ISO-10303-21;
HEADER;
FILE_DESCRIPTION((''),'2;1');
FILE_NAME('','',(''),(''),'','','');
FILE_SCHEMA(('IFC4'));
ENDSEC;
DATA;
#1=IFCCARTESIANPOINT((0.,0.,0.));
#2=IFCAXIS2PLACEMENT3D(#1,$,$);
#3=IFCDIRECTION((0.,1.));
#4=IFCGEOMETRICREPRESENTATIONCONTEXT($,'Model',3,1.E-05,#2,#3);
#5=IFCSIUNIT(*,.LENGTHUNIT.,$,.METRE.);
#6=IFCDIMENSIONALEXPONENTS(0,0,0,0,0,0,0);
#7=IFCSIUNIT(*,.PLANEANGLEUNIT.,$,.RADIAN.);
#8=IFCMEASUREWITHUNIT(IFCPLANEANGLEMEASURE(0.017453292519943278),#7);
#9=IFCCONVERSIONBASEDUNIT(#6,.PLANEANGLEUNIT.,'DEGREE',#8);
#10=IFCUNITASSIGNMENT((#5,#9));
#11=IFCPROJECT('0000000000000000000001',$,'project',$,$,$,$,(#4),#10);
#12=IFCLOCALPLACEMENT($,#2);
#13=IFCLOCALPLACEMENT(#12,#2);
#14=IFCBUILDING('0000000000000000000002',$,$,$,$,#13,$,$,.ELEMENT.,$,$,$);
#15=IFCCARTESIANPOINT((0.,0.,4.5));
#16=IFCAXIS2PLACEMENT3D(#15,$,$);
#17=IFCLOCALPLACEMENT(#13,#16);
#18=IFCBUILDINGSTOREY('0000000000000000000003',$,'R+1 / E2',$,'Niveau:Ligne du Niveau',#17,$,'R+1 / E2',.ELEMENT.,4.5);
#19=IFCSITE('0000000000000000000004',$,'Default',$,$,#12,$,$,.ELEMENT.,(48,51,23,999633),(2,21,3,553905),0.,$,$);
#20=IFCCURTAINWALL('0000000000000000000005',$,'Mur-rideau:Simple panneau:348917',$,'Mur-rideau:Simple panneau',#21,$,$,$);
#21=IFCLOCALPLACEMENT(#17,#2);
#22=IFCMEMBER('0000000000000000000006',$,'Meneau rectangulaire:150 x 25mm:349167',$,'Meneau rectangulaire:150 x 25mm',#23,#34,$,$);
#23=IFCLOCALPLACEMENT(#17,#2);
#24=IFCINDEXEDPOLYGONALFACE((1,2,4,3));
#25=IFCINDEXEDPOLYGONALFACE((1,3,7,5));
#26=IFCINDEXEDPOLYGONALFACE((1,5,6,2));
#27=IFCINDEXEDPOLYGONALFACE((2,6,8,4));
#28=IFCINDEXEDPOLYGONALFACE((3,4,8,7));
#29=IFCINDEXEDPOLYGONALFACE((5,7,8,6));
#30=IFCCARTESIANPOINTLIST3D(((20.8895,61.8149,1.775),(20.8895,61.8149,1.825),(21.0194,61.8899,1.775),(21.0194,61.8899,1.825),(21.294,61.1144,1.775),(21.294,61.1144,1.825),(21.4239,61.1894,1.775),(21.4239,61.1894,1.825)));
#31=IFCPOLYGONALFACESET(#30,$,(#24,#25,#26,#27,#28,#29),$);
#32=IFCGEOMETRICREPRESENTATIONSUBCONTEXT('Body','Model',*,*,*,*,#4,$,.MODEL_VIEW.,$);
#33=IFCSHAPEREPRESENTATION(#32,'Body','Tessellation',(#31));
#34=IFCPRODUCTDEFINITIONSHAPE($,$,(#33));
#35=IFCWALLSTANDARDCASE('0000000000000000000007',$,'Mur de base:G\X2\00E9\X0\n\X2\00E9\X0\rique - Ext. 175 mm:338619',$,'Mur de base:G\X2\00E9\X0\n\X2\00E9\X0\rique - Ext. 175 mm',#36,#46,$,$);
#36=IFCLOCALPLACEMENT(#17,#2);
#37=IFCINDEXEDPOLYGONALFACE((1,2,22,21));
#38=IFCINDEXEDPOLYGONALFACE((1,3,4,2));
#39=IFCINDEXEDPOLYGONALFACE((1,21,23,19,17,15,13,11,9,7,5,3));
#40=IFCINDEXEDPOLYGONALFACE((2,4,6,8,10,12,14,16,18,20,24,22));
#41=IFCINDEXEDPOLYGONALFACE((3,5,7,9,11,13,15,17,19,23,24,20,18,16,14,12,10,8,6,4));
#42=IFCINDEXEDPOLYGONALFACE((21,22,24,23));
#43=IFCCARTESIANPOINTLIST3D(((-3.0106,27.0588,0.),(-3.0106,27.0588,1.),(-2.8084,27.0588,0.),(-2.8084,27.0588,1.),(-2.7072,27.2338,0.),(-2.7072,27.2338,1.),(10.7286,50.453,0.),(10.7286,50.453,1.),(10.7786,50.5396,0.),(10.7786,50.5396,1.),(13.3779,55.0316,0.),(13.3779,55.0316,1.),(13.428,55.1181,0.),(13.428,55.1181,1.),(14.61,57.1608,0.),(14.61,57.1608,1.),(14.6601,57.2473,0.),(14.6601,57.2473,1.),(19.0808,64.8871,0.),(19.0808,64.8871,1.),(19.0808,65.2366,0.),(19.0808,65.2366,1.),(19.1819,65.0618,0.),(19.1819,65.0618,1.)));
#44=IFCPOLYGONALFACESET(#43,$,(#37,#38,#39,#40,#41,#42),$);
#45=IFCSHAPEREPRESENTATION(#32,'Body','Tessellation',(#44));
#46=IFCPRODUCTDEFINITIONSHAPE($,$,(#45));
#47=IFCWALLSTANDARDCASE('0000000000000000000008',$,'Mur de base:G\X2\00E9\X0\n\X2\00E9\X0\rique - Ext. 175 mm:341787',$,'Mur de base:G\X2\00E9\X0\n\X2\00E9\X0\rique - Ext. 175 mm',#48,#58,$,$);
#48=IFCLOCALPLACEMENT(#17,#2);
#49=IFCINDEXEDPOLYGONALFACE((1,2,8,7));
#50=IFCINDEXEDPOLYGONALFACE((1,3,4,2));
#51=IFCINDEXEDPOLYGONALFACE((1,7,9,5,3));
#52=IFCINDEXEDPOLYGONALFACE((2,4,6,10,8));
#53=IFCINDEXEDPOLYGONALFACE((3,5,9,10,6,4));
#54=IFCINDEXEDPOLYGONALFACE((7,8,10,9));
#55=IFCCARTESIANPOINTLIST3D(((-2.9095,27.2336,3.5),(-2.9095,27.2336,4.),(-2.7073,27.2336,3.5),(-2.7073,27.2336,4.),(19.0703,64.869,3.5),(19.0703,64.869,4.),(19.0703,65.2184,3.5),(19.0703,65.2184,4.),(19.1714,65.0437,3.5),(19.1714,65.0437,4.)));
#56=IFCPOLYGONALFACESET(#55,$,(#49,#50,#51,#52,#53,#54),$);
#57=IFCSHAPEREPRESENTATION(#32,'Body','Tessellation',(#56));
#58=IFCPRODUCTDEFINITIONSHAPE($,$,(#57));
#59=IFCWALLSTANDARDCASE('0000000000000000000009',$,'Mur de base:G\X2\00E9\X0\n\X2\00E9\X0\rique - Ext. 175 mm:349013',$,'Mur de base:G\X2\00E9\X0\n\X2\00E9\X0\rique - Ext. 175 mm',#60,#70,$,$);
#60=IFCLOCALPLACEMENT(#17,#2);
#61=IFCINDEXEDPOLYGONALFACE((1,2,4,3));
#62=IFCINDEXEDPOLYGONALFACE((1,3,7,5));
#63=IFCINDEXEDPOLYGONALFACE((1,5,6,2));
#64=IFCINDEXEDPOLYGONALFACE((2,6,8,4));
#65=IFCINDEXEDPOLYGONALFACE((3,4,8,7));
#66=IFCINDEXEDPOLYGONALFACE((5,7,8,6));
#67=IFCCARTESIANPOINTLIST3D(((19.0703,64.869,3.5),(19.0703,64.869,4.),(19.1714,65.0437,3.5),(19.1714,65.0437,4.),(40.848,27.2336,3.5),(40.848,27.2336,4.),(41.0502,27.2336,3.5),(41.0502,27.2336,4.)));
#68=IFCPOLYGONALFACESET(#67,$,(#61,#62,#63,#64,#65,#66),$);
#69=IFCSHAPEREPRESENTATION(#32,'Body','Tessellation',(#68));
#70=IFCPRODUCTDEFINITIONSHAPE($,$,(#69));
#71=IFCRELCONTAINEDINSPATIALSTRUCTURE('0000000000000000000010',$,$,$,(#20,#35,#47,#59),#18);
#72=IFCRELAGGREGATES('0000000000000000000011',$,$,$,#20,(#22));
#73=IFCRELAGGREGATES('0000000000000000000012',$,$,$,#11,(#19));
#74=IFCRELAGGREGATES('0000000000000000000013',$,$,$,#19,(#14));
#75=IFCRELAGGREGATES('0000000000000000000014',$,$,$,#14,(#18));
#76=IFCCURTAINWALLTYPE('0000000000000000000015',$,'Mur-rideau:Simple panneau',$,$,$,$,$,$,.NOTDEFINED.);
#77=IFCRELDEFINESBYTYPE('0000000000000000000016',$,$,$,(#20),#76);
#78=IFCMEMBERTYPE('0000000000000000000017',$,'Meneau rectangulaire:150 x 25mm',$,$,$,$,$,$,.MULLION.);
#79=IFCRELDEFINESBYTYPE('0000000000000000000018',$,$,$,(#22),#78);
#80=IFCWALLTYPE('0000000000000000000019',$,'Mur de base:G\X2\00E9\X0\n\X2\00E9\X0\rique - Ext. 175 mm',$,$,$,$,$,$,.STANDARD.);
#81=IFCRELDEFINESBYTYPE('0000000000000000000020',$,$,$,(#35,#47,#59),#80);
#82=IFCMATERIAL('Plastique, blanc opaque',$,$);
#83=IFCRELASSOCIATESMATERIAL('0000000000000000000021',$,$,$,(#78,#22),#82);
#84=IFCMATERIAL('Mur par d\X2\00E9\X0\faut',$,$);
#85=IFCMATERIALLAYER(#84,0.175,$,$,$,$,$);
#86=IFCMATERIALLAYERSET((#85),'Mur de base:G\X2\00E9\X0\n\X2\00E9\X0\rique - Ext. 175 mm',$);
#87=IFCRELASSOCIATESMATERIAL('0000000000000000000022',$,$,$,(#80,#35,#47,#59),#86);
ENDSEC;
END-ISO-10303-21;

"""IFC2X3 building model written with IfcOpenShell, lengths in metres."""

from ifc_helpers import new_model, entity, si_unit, converted_unit, direction, frame, origin, origin_2d_with_axis, place, context, subcontext, project, spatial, polyline, rectangle, outline, extrude, source, transform, mapped, material, layer, layer_set, layer_usage, type_object, type_shapes, element, aggregate, save


model = new_model("IFC2X3")

# Units and contexts
model_context = context("Model", 3, precision=1e-05, world=origin(), true_north=direction((0.0, 1.0)))
body_context = subcontext(model_context, "Body", "Model", "MODEL_VIEW")
ifc_project = project(units=[si_unit("LENGTHUNIT", "METRE"), converted_unit("PLANEANGLEUNIT", "DEGREE", entity("IfcPlaneAngleMeasure", 0.017453292519943278), si_unit("PLANEANGLEUNIT", "RADIAN"), dimensions=[0, 0, 0, 0, 0, 0, 0])], contexts=[model_context])

# Site, building, storey
site_placement = place(None, origin())
site = spatial("IfcSite", under=ifc_project, at=site_placement, Name="Default", CompositionType="ELEMENT", RefLatitude=(48, 51, 23, 999633), RefLongitude=(2, 21, 3, 553905), RefElevation=0.0)
building_placement = place(site_placement, origin())
building = spatial("IfcBuilding", under=site, at=building_placement, CompositionType="ELEMENT")
storey_placement = place(building_placement, frame((0.0, 0.0, 4.5)))
storey = spatial("IfcBuildingStorey", under=building, at=storey_placement, Name="R+1 / E2", ObjectType="Niveau:Ligne du Niveau", LongName="R+1 / E2", CompositionType="ELEMENT", Elevation=4.5)

# Curtain wall, member
curtain_wall_type = type_object("IfcCurtainWallType", Name="Mur-rideau:Simple panneau", PredefinedType="NOTDEFINED")
ifc_material_1 = material(Name="Plastique, blanc opaque")
curtain_wall_1_placement = place(storey_placement, frame((0.0, 0.0, -4.5)))
curtain_wall_1 = element("IfcCurtainWall", 1, at=curtain_wall_1_placement, inside=storey, type_object=curtain_wall_type, Name="Mur-rideau:Simple panneau:348917", ObjectType="Mur-rideau:Simple panneau")
member_type_1 = type_object("IfcMemberType", Name="Meneau rectangulaire:150 x 25mm", PredefinedType="MULLION", material=ifc_material_1)
shared_shape_1 = source(origin(), body_context, "Body", "SweptSolid", [
    extrude(rectangle(XDim=0.05, YDim=0.15, at=origin_2d_with_axis()), frame((0.0, 0.0, -0.8089), z_axis=(0.0, 0.0, 1.0), x_axis=(-1.0, 0.0, 0.0)), (0.0, 0.0, 1.0), 0.8089),
])
type_shapes(member_type_1, [shared_shape_1])
member_1_placement = place(curtain_wall_1_placement, frame((21.3589, 61.1519, 6.3), z_axis=(0.5, -0.866025, 0.0), x_axis=(0.0, 0.0, 1.0)))
member_1 = element("IfcMember", 2, at=member_1_placement, type_object=member_type_1, material=ifc_material_1, Name="Meneau rectangulaire:150 x 25mm:349167", ObjectType="Meneau rectangulaire:150 x 25mm", context=body_context, shape_type="MappedRepresentation", body=[
    mapped(shared_shape_1, transform((0.0, 0.0, 0.0), scale=1.0)),
])

aggregate(curtain_wall_1, [member_1])

# Walls
ifc_material_2 = material(Name="Mur par défaut")
ifc_layer_1 = layer(ifc_material_2, 0.175)
ifc_layer_set_1 = layer_set([ifc_layer_1], Name="Mur de base:Générique - Ext. 175 mm")
ifc_layer_usage_1 = layer_usage(ifc_layer_set_1, "AXIS2", "NEGATIVE", 0.0875)
wall_type = type_object("IfcWallType", Name="Mur de base:Générique - Ext. 175 mm", PredefinedType="STANDARD", material=ifc_layer_set_1)
wall_1_placement = place(storey_placement, frame((19.1566, 65.1927, 0.0), z_axis=(0.0, 0.0, 1.0), x_axis=(-0.500842, -0.865539, 0.0)))
element("IfcWallStandardCase", 3, at=wall_1_placement, inside=storey, type_object=wall_type, material=ifc_layer_usage_1, Name="Mur de base:Générique - Ext. 175 mm:338619", ObjectType="Mur de base:Générique - Ext. 175 mm", context=body_context, shape_type="SweptSolid", body=[
    extrude(outline(polyline([(44.1086, -0.0875), (44.0074, 0.0875), (43.8052, 0.0875), (16.9789, 0.0875), (16.8789, 0.0875), (11.6891, 0.0875), (11.5891, 0.0875), (9.2291, 0.0875), (9.1291, 0.0875), (0.3024, 0.0875), (0.1006, 0.0875), (0.0, -0.0875), (44.1086, -0.0875)])), origin(), (0.0, 0.0, 1.0), 1.0),
])
ifc_layer_usage_2 = layer_usage(ifc_layer_set_1, "AXIS2", "NEGATIVE", 0.0875)
wall_2_placement = place(storey_placement, frame((19.1461, 65.1745, 3.5), z_axis=(0.0, 0.0, 1.0), x_axis=(-0.500842, -0.865539, 0.0)))
element("IfcWallStandardCase", 4, at=wall_2_placement, inside=storey, type_object=wall_type, material=ifc_layer_usage_2, Name="Mur de base:Générique - Ext. 175 mm:341787", ObjectType="Mur de base:Générique - Ext. 175 mm", context=body_context, shape_type="SweptSolid", body=[
    extrude(outline(polyline([(43.8857, -0.0875), (43.7845, 0.0875), (0.3024, 0.0875), (0.1006, 0.0875), (0.0, -0.0875), (43.8857, -0.0875)])), origin(), (0.0, 0.0, 1.0), 0.5),
])
ifc_layer_usage_3 = layer_usage(ifc_layer_set_1, "AXIS2", "POSITIVE", -0.0875)
wall_3_placement = place(storey_placement, frame((19.0957, 64.9998, 3.5), z_axis=(0.0, 0.0, 1.0), x_axis=(0.500842, -0.865539, 0.0)))
element("IfcWallStandardCase", 5, at=wall_3_placement, inside=storey, type_object=wall_type, material=ifc_layer_usage_3, Name="Mur de base:Générique - Ext. 175 mm:349013", ObjectType="Mur de base:Générique - Ext. 175 mm", context=body_context, shape_type="SweptSolid", body=[
    extrude(outline(polyline([(43.5826, -0.0875), (43.6839, 0.0875), (0.0, 0.0875), (0.1006, -0.0875), (43.5826, -0.0875)])), origin(), (0.0, 0.0, 1.0), 0.5),
])

save(model, "model.ifc")
